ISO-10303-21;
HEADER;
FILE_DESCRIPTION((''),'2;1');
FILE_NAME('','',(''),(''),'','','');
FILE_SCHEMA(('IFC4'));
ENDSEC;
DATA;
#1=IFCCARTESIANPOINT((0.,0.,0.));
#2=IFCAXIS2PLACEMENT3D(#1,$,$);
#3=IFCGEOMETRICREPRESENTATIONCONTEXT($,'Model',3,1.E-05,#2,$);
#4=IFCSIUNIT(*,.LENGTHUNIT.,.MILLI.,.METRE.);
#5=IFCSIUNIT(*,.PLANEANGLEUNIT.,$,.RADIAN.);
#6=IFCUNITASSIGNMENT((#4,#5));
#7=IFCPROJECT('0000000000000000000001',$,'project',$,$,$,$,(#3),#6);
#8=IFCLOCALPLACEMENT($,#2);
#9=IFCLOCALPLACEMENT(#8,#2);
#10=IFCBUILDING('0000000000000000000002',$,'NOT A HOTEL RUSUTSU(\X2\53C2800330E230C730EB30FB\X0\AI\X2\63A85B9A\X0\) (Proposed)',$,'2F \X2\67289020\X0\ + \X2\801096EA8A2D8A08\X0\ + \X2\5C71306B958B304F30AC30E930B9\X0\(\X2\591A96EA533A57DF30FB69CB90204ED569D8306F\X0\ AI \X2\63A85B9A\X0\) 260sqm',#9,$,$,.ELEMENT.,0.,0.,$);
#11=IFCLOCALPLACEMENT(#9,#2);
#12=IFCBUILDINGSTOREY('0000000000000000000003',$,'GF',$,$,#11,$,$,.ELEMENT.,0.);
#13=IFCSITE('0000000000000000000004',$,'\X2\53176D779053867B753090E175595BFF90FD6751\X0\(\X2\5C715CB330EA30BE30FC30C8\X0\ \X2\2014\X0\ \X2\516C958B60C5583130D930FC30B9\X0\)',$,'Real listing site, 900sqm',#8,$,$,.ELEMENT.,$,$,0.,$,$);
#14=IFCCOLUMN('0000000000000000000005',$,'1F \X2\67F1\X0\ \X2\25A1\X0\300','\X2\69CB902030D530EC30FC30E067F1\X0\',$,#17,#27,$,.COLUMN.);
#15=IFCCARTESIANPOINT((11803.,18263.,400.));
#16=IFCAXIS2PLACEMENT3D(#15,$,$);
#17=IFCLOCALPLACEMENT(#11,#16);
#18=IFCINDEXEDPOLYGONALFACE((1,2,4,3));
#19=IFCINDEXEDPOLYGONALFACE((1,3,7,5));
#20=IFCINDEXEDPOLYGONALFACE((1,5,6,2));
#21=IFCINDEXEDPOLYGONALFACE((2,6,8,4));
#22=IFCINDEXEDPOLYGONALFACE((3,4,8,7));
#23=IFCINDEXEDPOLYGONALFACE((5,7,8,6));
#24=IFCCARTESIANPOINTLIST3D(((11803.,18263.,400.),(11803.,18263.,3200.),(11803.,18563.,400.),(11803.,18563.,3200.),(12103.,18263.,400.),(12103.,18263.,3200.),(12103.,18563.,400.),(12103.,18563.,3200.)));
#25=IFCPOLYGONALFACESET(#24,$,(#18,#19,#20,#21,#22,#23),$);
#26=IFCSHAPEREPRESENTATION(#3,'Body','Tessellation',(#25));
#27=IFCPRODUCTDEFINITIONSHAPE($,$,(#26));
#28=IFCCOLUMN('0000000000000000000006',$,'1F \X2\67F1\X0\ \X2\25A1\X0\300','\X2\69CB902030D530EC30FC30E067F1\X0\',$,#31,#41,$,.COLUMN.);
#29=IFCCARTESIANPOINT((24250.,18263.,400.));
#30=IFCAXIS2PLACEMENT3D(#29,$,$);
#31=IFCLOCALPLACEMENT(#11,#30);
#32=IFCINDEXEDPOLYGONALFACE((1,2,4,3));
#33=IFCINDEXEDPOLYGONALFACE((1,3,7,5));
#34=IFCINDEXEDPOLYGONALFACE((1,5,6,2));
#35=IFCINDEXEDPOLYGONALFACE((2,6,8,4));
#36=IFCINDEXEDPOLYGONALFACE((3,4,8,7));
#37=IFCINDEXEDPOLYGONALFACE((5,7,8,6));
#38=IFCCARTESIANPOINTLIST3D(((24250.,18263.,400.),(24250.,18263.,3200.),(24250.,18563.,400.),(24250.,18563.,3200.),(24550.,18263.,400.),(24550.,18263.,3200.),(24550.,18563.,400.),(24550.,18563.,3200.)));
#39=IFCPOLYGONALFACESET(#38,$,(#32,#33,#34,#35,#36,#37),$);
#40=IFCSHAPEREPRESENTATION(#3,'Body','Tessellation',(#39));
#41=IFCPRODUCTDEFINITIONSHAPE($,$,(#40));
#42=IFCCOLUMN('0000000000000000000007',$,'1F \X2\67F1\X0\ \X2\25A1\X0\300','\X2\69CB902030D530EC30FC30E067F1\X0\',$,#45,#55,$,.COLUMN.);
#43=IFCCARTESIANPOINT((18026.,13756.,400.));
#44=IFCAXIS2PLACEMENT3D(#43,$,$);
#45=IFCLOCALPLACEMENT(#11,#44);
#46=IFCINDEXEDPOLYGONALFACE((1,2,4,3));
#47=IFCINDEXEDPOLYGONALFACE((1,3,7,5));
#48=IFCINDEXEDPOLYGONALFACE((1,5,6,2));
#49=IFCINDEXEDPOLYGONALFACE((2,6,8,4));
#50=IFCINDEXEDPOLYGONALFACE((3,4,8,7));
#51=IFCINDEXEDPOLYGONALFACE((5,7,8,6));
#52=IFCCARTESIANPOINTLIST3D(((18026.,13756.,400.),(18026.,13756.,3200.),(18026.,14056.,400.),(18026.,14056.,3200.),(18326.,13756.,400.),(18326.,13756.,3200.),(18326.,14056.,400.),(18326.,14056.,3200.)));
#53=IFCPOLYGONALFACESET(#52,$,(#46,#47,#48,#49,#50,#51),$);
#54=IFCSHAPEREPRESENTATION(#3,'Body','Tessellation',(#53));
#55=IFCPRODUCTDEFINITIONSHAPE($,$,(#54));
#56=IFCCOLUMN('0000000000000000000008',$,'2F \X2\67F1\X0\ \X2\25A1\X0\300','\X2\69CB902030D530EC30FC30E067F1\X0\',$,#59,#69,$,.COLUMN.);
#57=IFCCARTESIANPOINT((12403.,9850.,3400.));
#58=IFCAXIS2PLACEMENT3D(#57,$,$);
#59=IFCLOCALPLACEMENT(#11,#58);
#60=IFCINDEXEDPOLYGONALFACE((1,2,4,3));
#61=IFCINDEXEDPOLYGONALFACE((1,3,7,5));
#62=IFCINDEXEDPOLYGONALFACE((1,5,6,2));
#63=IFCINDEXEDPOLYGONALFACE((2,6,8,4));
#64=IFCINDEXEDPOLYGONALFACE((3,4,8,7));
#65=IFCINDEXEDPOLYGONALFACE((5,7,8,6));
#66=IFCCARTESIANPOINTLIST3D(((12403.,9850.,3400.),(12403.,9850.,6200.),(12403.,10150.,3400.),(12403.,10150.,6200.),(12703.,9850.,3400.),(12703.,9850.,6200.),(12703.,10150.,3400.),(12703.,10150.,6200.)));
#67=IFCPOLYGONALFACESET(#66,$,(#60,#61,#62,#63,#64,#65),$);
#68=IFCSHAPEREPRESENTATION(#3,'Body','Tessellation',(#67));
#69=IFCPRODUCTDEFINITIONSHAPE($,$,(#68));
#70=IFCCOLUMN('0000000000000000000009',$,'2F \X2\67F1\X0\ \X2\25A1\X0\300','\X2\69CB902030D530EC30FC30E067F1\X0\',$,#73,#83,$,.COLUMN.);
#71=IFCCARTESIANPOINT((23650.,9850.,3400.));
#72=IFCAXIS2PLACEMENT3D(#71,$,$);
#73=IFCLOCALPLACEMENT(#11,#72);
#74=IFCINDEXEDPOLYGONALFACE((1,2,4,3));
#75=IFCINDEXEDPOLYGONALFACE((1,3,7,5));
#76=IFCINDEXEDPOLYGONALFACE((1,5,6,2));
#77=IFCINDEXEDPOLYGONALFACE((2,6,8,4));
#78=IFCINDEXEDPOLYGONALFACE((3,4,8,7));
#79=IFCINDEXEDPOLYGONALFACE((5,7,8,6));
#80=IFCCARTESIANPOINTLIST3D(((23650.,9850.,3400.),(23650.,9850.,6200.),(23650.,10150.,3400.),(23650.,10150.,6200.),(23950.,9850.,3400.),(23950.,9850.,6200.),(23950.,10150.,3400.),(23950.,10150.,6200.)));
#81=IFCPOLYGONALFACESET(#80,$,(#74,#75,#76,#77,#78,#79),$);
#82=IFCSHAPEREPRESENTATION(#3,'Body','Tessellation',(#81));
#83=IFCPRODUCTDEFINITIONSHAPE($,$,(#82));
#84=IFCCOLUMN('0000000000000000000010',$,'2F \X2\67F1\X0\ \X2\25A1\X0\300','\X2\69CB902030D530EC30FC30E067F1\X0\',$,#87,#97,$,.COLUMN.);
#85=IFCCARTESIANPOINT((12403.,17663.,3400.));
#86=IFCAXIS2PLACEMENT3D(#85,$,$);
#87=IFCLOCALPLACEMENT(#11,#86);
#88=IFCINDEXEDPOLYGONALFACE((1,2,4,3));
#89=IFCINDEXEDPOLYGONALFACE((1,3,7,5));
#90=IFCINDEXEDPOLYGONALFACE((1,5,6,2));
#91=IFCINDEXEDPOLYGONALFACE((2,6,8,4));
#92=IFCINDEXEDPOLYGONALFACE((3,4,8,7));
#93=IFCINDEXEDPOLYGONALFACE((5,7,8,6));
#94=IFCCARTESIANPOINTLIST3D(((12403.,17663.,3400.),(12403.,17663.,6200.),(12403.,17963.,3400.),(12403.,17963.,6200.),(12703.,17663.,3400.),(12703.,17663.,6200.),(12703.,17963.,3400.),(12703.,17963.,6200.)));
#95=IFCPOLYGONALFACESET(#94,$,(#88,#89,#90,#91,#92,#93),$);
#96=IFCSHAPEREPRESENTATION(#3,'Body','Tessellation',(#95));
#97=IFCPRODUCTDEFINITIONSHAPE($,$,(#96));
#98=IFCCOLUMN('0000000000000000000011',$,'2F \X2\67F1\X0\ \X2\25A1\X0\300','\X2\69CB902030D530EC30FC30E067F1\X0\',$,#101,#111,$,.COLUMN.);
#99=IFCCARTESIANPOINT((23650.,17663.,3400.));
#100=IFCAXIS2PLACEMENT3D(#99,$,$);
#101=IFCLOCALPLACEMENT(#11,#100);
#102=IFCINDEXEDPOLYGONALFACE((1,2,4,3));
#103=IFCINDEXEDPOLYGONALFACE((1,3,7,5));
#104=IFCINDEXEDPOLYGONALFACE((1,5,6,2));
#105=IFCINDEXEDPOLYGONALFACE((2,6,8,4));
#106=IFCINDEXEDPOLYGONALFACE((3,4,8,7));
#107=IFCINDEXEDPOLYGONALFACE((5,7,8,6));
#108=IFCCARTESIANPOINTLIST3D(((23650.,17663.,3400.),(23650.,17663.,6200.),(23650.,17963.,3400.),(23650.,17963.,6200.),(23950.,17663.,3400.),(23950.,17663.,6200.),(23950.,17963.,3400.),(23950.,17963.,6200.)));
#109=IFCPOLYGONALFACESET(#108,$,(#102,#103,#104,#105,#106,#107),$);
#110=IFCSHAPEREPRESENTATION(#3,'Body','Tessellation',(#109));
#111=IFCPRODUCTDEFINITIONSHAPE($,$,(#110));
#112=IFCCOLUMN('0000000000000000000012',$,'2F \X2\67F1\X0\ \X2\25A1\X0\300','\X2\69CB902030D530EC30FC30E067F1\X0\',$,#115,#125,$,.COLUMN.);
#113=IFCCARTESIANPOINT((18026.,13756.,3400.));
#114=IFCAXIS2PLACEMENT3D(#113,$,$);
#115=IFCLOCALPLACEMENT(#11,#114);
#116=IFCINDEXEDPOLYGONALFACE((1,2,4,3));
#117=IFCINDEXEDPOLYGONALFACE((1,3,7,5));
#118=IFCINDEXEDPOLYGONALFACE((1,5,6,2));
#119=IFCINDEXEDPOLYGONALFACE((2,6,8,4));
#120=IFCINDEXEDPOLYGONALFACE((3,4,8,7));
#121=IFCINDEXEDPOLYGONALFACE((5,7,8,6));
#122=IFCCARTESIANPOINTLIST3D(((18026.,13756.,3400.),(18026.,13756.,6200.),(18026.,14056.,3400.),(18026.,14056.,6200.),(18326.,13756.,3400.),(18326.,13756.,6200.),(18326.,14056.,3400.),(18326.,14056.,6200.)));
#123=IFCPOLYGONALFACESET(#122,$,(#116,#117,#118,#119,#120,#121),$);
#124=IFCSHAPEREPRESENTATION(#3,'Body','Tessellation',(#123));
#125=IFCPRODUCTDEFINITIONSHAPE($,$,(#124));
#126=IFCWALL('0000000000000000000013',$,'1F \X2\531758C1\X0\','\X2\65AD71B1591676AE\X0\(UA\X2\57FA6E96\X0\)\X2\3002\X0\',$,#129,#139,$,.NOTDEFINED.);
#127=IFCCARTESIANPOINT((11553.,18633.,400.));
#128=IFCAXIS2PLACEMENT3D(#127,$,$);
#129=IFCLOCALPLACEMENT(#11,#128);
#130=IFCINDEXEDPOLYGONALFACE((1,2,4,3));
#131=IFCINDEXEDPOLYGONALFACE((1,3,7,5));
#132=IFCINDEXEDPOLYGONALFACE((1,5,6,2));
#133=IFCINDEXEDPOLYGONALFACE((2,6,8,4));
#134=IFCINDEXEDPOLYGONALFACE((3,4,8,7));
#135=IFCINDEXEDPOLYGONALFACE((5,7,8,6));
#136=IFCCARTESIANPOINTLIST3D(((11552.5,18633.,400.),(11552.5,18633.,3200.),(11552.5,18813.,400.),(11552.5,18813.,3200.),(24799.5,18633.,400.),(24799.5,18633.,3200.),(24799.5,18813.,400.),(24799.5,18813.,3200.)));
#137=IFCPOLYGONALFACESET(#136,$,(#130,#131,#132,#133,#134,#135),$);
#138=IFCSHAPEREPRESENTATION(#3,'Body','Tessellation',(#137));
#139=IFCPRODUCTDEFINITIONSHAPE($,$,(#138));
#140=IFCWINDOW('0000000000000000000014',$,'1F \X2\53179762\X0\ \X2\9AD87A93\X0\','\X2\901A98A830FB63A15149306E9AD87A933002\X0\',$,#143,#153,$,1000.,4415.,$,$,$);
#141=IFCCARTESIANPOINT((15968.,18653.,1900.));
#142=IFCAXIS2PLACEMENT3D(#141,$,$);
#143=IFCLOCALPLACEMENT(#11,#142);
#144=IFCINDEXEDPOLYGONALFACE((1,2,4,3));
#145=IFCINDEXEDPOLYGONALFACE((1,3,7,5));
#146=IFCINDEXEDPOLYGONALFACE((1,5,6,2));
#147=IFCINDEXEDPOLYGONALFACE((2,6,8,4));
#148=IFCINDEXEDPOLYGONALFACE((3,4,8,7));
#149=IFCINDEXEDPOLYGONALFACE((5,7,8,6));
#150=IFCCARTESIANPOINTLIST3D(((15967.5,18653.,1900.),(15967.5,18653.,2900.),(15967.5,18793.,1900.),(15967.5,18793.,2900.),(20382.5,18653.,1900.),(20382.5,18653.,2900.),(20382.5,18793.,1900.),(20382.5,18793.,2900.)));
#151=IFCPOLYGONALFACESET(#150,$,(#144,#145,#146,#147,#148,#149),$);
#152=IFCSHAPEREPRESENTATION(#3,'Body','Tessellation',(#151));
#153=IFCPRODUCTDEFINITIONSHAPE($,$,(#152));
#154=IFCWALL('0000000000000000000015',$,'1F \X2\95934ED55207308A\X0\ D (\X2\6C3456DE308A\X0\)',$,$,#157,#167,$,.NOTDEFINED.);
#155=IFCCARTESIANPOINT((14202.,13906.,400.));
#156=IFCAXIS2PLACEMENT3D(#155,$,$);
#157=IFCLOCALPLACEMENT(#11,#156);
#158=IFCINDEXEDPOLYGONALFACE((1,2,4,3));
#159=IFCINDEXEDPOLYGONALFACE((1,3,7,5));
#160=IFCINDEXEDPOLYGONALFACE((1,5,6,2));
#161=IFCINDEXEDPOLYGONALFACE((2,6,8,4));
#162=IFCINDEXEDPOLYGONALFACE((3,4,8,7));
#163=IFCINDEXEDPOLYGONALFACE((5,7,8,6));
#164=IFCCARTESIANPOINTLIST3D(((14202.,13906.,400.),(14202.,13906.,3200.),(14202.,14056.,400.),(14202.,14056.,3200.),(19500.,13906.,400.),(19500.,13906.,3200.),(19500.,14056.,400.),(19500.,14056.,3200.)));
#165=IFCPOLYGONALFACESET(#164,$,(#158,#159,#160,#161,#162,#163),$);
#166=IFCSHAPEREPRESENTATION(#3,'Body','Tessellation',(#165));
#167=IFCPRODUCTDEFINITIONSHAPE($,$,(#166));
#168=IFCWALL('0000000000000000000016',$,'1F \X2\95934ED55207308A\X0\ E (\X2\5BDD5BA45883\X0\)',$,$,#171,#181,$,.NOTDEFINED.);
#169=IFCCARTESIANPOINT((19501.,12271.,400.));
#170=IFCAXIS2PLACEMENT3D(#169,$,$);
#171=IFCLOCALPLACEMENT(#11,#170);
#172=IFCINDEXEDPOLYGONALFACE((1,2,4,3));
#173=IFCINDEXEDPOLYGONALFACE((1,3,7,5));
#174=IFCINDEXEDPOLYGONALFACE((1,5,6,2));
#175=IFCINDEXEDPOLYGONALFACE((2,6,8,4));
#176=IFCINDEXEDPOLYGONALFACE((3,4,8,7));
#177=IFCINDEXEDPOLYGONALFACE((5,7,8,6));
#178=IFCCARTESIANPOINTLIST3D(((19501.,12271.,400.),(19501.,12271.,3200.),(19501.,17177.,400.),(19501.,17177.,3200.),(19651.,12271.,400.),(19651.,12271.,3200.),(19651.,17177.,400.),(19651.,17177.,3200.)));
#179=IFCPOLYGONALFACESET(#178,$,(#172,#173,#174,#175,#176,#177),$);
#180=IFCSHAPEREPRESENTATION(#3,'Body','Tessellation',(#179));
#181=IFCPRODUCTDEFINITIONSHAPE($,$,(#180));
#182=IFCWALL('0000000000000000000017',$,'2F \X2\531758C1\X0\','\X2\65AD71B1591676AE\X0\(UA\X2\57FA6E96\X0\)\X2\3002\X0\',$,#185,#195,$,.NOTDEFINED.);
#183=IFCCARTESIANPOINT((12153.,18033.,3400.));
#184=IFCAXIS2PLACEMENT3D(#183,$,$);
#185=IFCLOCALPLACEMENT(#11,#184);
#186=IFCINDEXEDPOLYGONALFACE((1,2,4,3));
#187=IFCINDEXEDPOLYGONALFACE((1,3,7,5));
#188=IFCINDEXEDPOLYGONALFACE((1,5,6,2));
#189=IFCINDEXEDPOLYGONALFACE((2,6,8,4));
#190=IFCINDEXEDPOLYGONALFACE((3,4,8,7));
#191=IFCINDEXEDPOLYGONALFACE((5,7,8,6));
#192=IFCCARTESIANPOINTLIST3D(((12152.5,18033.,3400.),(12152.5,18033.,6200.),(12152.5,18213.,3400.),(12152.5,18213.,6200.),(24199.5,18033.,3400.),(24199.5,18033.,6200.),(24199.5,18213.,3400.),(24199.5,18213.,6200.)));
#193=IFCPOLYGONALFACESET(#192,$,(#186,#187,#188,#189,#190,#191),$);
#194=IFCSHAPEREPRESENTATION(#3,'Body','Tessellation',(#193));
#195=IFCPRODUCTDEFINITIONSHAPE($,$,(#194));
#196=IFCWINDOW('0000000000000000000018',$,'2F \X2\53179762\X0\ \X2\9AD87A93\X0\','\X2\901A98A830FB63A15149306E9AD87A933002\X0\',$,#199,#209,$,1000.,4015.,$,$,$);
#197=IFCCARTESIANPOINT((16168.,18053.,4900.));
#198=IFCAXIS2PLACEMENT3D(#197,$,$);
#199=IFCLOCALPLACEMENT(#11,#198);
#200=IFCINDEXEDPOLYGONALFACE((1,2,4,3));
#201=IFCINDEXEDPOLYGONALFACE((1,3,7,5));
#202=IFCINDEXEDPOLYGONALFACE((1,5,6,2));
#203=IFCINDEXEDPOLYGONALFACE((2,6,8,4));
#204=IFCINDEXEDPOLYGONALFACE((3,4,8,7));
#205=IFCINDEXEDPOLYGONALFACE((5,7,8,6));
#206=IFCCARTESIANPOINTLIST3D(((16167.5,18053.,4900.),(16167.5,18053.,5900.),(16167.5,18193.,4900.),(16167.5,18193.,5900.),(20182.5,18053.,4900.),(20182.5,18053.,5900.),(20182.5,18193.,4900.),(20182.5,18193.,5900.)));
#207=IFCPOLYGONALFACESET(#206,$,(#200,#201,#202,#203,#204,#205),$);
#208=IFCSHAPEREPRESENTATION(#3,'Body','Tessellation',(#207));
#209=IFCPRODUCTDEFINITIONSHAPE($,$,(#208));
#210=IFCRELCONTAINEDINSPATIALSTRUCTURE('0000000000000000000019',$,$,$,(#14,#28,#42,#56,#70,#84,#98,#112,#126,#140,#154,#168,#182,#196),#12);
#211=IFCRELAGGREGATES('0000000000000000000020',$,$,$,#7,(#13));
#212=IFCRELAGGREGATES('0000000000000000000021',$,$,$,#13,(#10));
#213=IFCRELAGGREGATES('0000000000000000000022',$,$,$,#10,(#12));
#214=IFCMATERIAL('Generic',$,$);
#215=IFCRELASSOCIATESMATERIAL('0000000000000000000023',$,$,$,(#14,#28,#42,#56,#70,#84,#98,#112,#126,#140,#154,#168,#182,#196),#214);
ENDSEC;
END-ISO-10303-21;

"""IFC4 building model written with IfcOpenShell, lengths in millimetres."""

from ifc_helpers import new_model, si_unit, frame, frame_2d, origin, place, context, project, spatial, rectangle, extrude, material, element, fill, save


model = new_model("IFC4")

# Units and contexts
model_context = context("Model", 3, precision=1e-05, world=origin())
ifc_project = project(units=[si_unit("LENGTHUNIT", "METRE", prefix="MILLI"), si_unit("PLANEANGLEUNIT", "RADIAN")], contexts=[model_context])

# Site, building, storey
site_placement = place(None, origin())
site = spatial("IfcSite", under=ifc_project, at=site_placement, Name="北海道虻田郡留寿都村(山岳リゾート — 公開情報ベース)", ObjectType="Real listing site, 900sqm", CompositionType="ELEMENT", RefElevation=0.0)
building_placement = place(site_placement, origin())
building = spatial("IfcBuilding", under=site, at=building_placement, Name="NOT A HOTEL RUSUTSU(参考モデル・AI推定) (Proposed)", ObjectType="2F 木造 + 耐雪設計 + 山に開くガラス(多雪区域・構造仕様は AI 推定) 260sqm", CompositionType="ELEMENT", ElevationOfRefHeight=0.0, ElevationOfTerrain=0.0)
storey_placement = place(building_placement, origin())
storey = spatial("IfcBuildingStorey", under=building, at=storey_placement, Name="GF", CompositionType="ELEMENT", Elevation=0.0)

# Columns
ifc_material_1 = material(Name="Generic")
column_1_placement = place(storey_placement, frame((11803.0, 18263.0, 400.0)))
element("IfcColumn", 1, at=column_1_placement, inside=storey, material=ifc_material_1, Name="1F 柱 □300", Description="構造フレーム柱", PredefinedType="COLUMN", context=model_context, shape_type="SweptSolid", body=[
    extrude(rectangle(XDim=300.0, YDim=300.0, at=frame_2d((150.0, 150.0))), frame((11803.0, 18263.0, 400.0)), (0.0, 0.0, 1.0), 2800.0),
])
column_2_placement = place(storey_placement, frame((24250.0, 18263.0, 400.0)))
element("IfcColumn", 2, at=column_2_placement, inside=storey, material=ifc_material_1, Name="1F 柱 □300", Description="構造フレーム柱", PredefinedType="COLUMN", context=model_context, shape_type="SweptSolid", body=[
    extrude(rectangle(XDim=300.0, YDim=300.0, at=frame_2d((150.0, 150.0))), frame((24250.0, 18263.0, 400.0)), (0.0, 0.0, 1.0), 2800.0),
])
column_3_placement = place(storey_placement, frame((18026.0, 13756.0, 400.0)))
element("IfcColumn", 3, at=column_3_placement, inside=storey, material=ifc_material_1, Name="1F 柱 □300", Description="構造フレーム柱", PredefinedType="COLUMN", context=model_context, shape_type="SweptSolid", body=[
    extrude(rectangle(XDim=300.0, YDim=300.0, at=frame_2d((150.0, 150.0))), frame((18026.0, 13756.0, 400.0)), (0.0, 0.0, 1.0), 2800.0),
])
column_4_placement = place(storey_placement, frame((12403.0, 9850.0, 3400.0)))
element("IfcColumn", 4, at=column_4_placement, inside=storey, material=ifc_material_1, Name="2F 柱 □300", Description="構造フレーム柱", PredefinedType="COLUMN", context=model_context, shape_type="SweptSolid", body=[
    extrude(rectangle(XDim=300.0, YDim=300.0, at=frame_2d((150.0, 150.0))), frame((12403.0, 9850.0, 3400.0)), (0.0, 0.0, 1.0), 2800.0),
])
column_5_placement = place(storey_placement, frame((23650.0, 9850.0, 3400.0)))
element("IfcColumn", 5, at=column_5_placement, inside=storey, material=ifc_material_1, Name="2F 柱 □300", Description="構造フレーム柱", PredefinedType="COLUMN", context=model_context, shape_type="SweptSolid", body=[
    extrude(rectangle(XDim=300.0, YDim=300.0, at=frame_2d((150.0, 150.0))), frame((23650.0, 9850.0, 3400.0)), (0.0, 0.0, 1.0), 2800.0),
])
column_6_placement = place(storey_placement, frame((12403.0, 17663.0, 3400.0)))
element("IfcColumn", 6, at=column_6_placement, inside=storey, material=ifc_material_1, Name="2F 柱 □300", Description="構造フレーム柱", PredefinedType="COLUMN", context=model_context, shape_type="SweptSolid", body=[
    extrude(rectangle(XDim=300.0, YDim=300.0, at=frame_2d((150.0, 150.0))), frame((12403.0, 17663.0, 3400.0)), (0.0, 0.0, 1.0), 2800.0),
])
column_7_placement = place(storey_placement, frame((23650.0, 17663.0, 3400.0)))
element("IfcColumn", 7, at=column_7_placement, inside=storey, material=ifc_material_1, Name="2F 柱 □300", Description="構造フレーム柱", PredefinedType="COLUMN", context=model_context, shape_type="SweptSolid", body=[
    extrude(rectangle(XDim=300.0, YDim=300.0, at=frame_2d((150.0, 150.0))), frame((23650.0, 17663.0, 3400.0)), (0.0, 0.0, 1.0), 2800.0),
])
column_8_placement = place(storey_placement, frame((18026.0, 13756.0, 3400.0)))
element("IfcColumn", 8, at=column_8_placement, inside=storey, material=ifc_material_1, Name="2F 柱 □300", Description="構造フレーム柱", PredefinedType="COLUMN", context=model_context, shape_type="SweptSolid", body=[
    extrude(rectangle(XDim=300.0, YDim=300.0, at=frame_2d((150.0, 150.0))), frame((18026.0, 13756.0, 3400.0)), (0.0, 0.0, 1.0), 2800.0),
])

# Wall, opening, window
wall_1_placement = place(storey_placement, frame((11553.0, 18633.0, 400.0)))
wall_1 = element("IfcWall", 9, at=wall_1_placement, inside=storey, material=ifc_material_1, Name="1F 北壁", Description="断熱外皮(UA基準)。", PredefinedType="NOTDEFINED", context=model_context, shape_type="SweptSolid", body=[
    extrude(rectangle(XDim=13247.0, YDim=180.0, at=frame_2d((6623.0, 90.0))), frame((11553.0, 18633.0, 400.0)), (0.0, 0.0, 1.0), 2800.0),
])
opening_1_placement = place(storey_placement, frame((15968.0, 18653.0, 1900.0)))
opening_1 = element("IfcOpeningElement", 10, at=opening_1_placement, cuts=wall_1, PredefinedType="NOTDEFINED", context=model_context, shape_type="SweptSolid", body=[
    extrude(rectangle(XDim=4415.0, YDim=140.0, at=frame_2d((2207.0, 70.0))), frame((15968.0, 18653.0, 1900.0)), (0.0, 0.0, 1.0), 1000.0),
])
window_1_placement = place(storey_placement, frame((15968.0, 18653.0, 1900.0)))
window_1 = element("IfcWindow", 11, at=window_1_placement, inside=storey, material=ifc_material_1, Name="1F 北面 高窓", Description="通風・採光の高窓。", OverallHeight=1000.0, OverallWidth=4415.0, context=model_context, shape_type="SweptSolid", body=[
    extrude(rectangle(XDim=4415.0, YDim=140.0, at=frame_2d((2207.0, 70.0))), frame((15968.0, 18653.0, 1900.0)), (0.0, 0.0, 1.0), 1000.0),
])
fill(opening_1, window_1)

# Walls
wall_2_placement = place(storey_placement, frame((14202.0, 13906.0, 400.0)))
element("IfcWall", 12, at=wall_2_placement, inside=storey, material=ifc_material_1, Name="1F 間仕切り D (水回り)", PredefinedType="NOTDEFINED", context=model_context, shape_type="SweptSolid", body=[
    extrude(rectangle(XDim=5298.0, YDim=150.0, at=frame_2d((2649.0, 75.0))), frame((14202.0, 13906.0, 400.0)), (0.0, 0.0, 1.0), 2800.0),
])
wall_3_placement = place(storey_placement, frame((19501.0, 12271.0, 400.0)))
element("IfcWall", 13, at=wall_3_placement, inside=storey, material=ifc_material_1, Name="1F 間仕切り E (寝室境)", PredefinedType="NOTDEFINED", context=model_context, shape_type="SweptSolid", body=[
    extrude(rectangle(XDim=150.0, YDim=4906.0, at=frame_2d((75.0, 2453.0))), frame((19501.0, 12271.0, 400.0)), (0.0, 0.0, 1.0), 2800.0),
])

# Wall, opening, window
wall_4_placement = place(storey_placement, frame((12153.0, 18033.0, 3400.0)))
wall_4 = element("IfcWall", 14, at=wall_4_placement, inside=storey, material=ifc_material_1, Name="2F 北壁", Description="断熱外皮(UA基準)。", PredefinedType="NOTDEFINED", context=model_context, shape_type="SweptSolid", body=[
    extrude(rectangle(XDim=12047.0, YDim=180.0, at=frame_2d((6023.0, 90.0))), frame((12153.0, 18033.0, 3400.0)), (0.0, 0.0, 1.0), 2800.0),
])
opening_2_placement = place(storey_placement, frame((16168.0, 18053.0, 4900.0)))
opening_2 = element("IfcOpeningElement", 15, at=opening_2_placement, cuts=wall_4, PredefinedType="NOTDEFINED", context=model_context, shape_type="SweptSolid", body=[
    extrude(rectangle(XDim=4015.0, YDim=140.0, at=frame_2d((2007.0, 70.0))), frame((16168.0, 18053.0, 4900.0)), (0.0, 0.0, 1.0), 1000.0),
])
window_2_placement = place(storey_placement, frame((16168.0, 18053.0, 4900.0)))
window_2 = element("IfcWindow", 16, at=window_2_placement, inside=storey, material=ifc_material_1, Name="2F 北面 高窓", Description="通風・採光の高窓。", OverallHeight=1000.0, OverallWidth=4015.0, context=model_context, shape_type="SweptSolid", body=[
    extrude(rectangle(XDim=4015.0, YDim=140.0, at=frame_2d((2007.0, 70.0))), frame((16168.0, 18053.0, 4900.0)), (0.0, 0.0, 1.0), 1000.0),
])
fill(opening_2, window_2)

save(model, "model.ifc")
